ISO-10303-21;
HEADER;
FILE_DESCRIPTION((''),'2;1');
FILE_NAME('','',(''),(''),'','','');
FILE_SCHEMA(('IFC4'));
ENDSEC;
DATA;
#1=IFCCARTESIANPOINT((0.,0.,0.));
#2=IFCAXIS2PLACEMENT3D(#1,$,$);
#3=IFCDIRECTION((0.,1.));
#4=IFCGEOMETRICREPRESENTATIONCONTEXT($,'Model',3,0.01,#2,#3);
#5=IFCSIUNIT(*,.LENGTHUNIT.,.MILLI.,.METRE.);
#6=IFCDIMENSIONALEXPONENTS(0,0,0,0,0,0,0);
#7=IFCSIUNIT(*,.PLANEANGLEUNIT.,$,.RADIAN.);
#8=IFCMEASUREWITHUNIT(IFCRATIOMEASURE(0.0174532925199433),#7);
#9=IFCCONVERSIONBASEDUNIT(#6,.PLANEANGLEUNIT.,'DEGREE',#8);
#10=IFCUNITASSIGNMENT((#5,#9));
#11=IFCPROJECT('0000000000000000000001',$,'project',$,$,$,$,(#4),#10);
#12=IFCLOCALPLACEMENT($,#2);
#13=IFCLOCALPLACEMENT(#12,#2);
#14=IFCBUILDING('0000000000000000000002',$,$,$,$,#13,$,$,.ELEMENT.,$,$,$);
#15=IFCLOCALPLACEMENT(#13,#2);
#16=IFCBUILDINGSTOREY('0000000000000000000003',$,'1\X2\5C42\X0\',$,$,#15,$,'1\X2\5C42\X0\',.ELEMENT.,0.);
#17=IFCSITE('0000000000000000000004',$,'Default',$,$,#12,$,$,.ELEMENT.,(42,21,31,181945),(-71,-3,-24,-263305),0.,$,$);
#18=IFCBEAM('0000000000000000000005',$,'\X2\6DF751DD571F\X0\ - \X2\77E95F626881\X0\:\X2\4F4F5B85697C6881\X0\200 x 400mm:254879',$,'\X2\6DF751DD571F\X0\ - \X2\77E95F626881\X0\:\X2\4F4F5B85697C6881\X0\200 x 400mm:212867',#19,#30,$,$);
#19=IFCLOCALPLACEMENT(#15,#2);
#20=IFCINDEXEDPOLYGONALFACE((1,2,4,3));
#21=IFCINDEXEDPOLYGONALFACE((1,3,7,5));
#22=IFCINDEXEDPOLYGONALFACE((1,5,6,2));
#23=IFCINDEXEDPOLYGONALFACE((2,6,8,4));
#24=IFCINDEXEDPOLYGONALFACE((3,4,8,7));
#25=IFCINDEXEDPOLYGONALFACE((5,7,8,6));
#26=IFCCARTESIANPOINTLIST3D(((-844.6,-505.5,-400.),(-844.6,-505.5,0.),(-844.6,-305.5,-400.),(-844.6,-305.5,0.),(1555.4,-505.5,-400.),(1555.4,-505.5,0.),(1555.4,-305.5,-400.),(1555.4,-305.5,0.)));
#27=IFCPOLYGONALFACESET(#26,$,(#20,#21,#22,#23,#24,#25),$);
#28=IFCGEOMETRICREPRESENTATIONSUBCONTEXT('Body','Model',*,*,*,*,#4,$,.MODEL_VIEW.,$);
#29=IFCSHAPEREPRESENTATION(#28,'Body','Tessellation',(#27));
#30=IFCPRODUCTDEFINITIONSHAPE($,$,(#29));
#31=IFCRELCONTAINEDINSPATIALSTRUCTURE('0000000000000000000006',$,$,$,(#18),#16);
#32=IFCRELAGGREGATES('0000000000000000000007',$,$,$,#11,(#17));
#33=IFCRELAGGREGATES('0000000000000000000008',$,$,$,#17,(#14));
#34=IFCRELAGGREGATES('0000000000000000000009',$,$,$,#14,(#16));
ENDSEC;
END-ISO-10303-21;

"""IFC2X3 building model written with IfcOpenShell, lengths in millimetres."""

from ifc_helpers import new_model, entity, si_unit, converted_unit, direction, frame, frame_2d, origin, place, context, subcontext, project, spatial, rectangle, extrude, element, save


model = new_model("IFC2X3")

# Units and contexts
model_context = context("Model", 3, precision=0.01, world=origin(), true_north=direction((0.0, 1.0)))
body_context = subcontext(model_context, "Body", "Model", "MODEL_VIEW")
ifc_project = project(units=[si_unit("LENGTHUNIT", "METRE", prefix="MILLI"), converted_unit("PLANEANGLEUNIT", "DEGREE", entity("IfcRatioMeasure", 0.0174532925199433), si_unit("PLANEANGLEUNIT", "RADIAN"), dimensions=[0, 0, 0, 0, 0, 0, 0])], contexts=[model_context])

# Site, building, storey
site_placement = place(None, origin())
site = spatial("IfcSite", under=ifc_project, at=site_placement, Name="Default", CompositionType="ELEMENT", RefLatitude=(42, 21, 31, 181945), RefLongitude=(-71, -3, -24, -263305), RefElevation=0.0)
building_placement = place(site_placement, origin())
building = spatial("IfcBuilding", under=site, at=building_placement, CompositionType="ELEMENT")
storey_placement = place(building_placement, origin())
storey = spatial("IfcBuildingStorey", under=building, at=storey_placement, Name="1层", LongName="1层", CompositionType="ELEMENT", Elevation=0.0)

# Beam
beam_placement = place(storey_placement, frame((-944.6, -405.5, 0.0)))
element("IfcBeam", 1, at=beam_placement, inside=storey, Name="混凝土 - 矩形梁:住宅楼梁200 x 400mm:254879", ObjectType="混凝土 - 矩形梁:住宅楼梁200 x 400mm:212867", context=body_context, shape_type="SweptSolid", body=[
    extrude(rectangle(XDim=400.0, YDim=200.0, at=frame_2d((0.0, 0.0), x_axis=(1.0, 0.0))), frame((100.0, 0.0, -200.0), z_axis=(1.0, 0.0, 0.0), x_axis=(0.0, 0.0, -1.0)), (0.0, 0.0, 1.0), 2400.0),
])

save(model, "model.ifc")
